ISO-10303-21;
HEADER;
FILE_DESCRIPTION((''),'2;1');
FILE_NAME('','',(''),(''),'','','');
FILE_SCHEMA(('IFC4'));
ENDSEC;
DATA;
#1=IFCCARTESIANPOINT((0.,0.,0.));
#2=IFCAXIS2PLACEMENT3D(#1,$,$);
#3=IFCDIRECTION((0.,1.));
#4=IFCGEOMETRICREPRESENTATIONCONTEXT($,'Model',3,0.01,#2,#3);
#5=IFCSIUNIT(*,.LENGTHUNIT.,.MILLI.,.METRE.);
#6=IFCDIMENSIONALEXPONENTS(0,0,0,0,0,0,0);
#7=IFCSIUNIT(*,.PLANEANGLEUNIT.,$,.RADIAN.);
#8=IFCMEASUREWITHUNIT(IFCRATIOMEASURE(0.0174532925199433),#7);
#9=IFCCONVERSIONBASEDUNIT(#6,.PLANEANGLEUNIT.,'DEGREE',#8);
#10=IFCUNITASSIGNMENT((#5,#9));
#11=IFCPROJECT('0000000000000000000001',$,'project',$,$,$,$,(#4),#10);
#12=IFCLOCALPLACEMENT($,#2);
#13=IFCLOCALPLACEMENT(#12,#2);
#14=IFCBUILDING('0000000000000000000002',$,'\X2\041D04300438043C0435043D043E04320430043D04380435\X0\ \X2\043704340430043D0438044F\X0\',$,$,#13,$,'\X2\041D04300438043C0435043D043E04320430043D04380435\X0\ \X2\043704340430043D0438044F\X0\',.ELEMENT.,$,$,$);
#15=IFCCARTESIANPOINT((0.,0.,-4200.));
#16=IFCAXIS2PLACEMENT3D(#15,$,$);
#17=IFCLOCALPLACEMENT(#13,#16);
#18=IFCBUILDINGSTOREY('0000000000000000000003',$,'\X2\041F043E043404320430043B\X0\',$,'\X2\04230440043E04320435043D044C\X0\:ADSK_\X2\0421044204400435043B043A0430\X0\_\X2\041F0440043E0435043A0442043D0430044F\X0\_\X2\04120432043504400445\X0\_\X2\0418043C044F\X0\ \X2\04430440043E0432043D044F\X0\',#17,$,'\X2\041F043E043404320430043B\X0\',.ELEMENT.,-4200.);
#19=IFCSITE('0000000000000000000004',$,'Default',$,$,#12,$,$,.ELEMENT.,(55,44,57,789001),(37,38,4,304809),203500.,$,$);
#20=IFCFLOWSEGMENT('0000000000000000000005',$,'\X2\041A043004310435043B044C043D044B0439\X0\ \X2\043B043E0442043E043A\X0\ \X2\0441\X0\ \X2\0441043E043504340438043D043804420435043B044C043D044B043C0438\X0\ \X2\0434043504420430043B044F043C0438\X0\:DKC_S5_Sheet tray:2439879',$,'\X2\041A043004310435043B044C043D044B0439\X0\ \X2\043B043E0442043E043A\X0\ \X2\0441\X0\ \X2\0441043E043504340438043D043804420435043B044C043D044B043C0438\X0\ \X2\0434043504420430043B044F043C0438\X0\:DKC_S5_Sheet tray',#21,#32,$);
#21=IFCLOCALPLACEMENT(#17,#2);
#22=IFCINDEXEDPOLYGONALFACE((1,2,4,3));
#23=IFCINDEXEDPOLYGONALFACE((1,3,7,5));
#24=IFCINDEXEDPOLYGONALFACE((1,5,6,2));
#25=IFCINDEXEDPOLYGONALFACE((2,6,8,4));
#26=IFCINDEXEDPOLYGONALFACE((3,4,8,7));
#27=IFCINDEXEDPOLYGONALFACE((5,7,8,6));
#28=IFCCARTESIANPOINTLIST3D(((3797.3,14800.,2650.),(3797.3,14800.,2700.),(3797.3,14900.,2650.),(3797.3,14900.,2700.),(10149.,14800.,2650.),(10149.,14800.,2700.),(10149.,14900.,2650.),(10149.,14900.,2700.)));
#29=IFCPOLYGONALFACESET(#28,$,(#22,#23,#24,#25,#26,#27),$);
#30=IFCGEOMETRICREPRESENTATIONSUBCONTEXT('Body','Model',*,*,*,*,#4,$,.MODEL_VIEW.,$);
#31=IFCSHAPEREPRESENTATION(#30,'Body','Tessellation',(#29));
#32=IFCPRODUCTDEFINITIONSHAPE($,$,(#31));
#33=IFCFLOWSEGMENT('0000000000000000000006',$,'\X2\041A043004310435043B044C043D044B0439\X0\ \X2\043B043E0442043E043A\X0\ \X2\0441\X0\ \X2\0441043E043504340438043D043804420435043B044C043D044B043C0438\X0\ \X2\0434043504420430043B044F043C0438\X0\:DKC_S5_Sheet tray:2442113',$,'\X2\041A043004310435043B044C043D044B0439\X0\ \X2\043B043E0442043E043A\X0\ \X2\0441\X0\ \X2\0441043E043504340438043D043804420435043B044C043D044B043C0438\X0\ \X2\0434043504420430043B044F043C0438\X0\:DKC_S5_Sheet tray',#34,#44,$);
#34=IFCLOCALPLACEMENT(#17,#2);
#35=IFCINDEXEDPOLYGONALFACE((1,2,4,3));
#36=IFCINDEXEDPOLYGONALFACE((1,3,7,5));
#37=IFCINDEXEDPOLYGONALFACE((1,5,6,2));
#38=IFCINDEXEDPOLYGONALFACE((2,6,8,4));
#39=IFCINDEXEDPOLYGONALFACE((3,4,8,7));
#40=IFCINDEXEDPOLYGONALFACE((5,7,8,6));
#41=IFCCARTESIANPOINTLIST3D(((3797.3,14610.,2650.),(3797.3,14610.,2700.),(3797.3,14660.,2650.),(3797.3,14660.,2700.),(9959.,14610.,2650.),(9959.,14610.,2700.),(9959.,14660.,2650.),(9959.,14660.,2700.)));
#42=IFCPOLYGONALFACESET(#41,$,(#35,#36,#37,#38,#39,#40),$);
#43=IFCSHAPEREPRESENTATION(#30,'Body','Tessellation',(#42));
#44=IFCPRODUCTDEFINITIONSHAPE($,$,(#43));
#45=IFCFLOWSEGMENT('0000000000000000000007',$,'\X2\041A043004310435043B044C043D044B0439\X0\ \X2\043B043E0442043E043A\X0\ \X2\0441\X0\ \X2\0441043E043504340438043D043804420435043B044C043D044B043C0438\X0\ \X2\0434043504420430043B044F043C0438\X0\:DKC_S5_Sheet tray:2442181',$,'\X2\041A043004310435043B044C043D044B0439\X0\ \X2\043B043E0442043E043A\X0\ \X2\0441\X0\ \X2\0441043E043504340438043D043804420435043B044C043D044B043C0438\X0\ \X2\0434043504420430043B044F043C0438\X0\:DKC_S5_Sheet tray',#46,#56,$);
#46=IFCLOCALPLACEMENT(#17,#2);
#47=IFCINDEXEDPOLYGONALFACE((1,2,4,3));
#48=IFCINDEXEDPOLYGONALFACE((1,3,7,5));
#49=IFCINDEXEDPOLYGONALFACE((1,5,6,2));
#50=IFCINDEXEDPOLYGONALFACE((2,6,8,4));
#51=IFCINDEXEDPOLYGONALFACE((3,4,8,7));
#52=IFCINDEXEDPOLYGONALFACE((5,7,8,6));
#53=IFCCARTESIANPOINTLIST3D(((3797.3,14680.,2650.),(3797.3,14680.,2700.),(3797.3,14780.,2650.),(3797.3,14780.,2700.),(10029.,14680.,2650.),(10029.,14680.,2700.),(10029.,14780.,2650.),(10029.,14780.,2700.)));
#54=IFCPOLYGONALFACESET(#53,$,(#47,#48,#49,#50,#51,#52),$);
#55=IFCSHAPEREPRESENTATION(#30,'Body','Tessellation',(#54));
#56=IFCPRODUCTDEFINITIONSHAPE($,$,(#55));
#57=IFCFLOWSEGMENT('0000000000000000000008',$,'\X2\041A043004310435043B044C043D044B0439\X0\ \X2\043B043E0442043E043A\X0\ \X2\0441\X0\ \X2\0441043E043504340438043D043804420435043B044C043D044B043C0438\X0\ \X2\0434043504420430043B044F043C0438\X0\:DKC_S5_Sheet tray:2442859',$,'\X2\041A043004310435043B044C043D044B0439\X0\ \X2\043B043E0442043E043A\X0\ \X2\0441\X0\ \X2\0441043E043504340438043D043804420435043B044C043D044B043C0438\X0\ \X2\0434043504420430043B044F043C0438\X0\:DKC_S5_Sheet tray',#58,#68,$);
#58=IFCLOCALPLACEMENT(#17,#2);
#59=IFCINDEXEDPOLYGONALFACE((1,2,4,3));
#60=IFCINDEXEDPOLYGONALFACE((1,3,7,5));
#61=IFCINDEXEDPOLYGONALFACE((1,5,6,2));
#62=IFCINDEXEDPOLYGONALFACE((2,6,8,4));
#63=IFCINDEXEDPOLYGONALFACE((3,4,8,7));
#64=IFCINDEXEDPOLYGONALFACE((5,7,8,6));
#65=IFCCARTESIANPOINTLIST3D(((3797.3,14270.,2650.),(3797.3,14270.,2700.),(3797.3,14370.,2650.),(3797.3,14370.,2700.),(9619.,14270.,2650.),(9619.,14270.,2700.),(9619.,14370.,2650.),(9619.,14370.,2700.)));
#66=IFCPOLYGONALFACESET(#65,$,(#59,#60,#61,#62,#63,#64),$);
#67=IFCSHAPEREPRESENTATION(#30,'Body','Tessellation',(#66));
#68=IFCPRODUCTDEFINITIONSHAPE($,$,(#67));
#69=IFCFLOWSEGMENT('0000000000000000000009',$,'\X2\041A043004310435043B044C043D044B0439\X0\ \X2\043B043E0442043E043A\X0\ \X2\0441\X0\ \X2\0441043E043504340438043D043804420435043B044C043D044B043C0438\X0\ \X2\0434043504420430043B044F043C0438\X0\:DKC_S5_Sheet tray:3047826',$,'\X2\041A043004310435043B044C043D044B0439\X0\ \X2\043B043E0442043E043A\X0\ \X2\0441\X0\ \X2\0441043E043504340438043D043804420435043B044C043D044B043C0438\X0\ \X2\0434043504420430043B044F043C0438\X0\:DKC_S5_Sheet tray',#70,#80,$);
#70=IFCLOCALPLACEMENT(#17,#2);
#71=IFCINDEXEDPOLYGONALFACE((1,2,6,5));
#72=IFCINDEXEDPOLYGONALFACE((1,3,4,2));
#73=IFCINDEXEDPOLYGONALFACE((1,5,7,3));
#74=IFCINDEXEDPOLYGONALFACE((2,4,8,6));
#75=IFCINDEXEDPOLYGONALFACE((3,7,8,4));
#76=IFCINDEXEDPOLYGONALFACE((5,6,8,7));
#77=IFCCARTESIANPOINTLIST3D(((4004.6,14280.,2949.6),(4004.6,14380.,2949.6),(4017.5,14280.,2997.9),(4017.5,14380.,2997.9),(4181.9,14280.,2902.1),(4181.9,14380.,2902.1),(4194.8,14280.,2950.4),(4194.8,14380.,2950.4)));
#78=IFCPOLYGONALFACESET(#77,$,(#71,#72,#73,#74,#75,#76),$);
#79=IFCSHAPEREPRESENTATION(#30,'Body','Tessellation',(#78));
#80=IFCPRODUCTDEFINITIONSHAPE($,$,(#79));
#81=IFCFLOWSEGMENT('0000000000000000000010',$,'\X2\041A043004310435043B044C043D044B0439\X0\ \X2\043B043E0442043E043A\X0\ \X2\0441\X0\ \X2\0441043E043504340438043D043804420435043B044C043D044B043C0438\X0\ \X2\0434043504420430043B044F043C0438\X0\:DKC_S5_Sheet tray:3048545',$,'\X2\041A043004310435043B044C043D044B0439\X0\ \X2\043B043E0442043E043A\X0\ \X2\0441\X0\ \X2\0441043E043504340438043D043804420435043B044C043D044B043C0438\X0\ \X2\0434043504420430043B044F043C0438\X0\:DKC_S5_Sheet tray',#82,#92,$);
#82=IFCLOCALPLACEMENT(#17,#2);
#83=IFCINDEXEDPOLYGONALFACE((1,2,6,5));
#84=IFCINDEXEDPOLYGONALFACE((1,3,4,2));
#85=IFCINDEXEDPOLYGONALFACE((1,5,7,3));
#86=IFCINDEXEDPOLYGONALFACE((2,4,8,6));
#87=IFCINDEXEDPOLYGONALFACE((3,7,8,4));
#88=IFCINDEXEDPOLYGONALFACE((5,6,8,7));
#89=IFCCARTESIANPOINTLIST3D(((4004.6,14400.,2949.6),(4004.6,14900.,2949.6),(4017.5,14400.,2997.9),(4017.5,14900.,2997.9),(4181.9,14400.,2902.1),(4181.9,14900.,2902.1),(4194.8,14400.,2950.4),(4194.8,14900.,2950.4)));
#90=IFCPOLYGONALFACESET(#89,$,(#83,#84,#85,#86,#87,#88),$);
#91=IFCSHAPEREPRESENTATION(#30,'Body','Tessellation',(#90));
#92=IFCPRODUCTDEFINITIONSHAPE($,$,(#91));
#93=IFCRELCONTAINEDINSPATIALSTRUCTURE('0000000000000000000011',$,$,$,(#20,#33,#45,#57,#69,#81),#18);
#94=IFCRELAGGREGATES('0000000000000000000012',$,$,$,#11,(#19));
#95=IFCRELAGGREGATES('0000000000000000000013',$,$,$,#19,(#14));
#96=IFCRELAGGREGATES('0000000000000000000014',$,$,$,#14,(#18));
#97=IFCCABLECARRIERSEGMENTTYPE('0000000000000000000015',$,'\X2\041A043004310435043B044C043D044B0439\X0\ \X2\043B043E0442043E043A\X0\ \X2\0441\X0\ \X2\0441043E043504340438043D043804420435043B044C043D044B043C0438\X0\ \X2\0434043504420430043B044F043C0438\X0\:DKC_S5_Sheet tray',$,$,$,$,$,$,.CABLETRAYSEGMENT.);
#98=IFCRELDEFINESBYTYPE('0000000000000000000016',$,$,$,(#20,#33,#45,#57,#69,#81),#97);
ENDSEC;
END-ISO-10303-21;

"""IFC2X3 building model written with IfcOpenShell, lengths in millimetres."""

from ifc_helpers import new_model, entity, si_unit, converted_unit, direction, frame, frame_2d, origin, origin_2d_with_axis, place, context, subcontext, project, spatial, rectangle, extrude, type_object, element, save


model = new_model("IFC2X3")

# Units and contexts
model_context = context("Model", 3, precision=0.01, world=origin(), true_north=direction((0.0, 1.0)))
body_context = subcontext(model_context, "Body", "Model", "MODEL_VIEW")
ifc_project = project(units=[si_unit("LENGTHUNIT", "METRE", prefix="MILLI"), converted_unit("PLANEANGLEUNIT", "DEGREE", entity("IfcRatioMeasure", 0.0174532925199433), si_unit("PLANEANGLEUNIT", "RADIAN"), dimensions=[0, 0, 0, 0, 0, 0, 0])], contexts=[model_context])

# Site, building, storey
site_placement = place(None, origin())
site = spatial("IfcSite", under=ifc_project, at=site_placement, Name="Default", CompositionType="ELEMENT", RefLatitude=(55, 44, 57, 789001), RefLongitude=(37, 38, 4, 304809), RefElevation=203500.0)
building_placement = place(site_placement, origin())
building = spatial("IfcBuilding", under=site, at=building_placement, Name="Наименование здания", LongName="Наименование здания", CompositionType="ELEMENT")
storey_placement = place(building_placement, frame((0.0, 0.0, -4200.0)))
storey = spatial("IfcBuildingStorey", under=building, at=storey_placement, Name="Подвал", ObjectType="Уровень:ADSK_Стрелка_Проектная_Вверх_Имя уровня", LongName="Подвал", CompositionType="ELEMENT", Elevation=-4200.0)

# Flow segments
cable_carrier_segment_type = type_object("IfcCableCarrierSegmentType", Name="Кабельный лоток с соединительными деталями:DKC_S5_Sheet tray", PredefinedType="CABLETRAYSEGMENT")
flow_segment_1_placement = place(storey_placement, frame((3797.2, 14800.0, 2650.0)))
element("IfcFlowSegment", 1, at=flow_segment_1_placement, inside=storey, type_object=cable_carrier_segment_type, Name="Кабельный лоток с соединительными деталями:DKC_S5_Sheet tray:2439879", ObjectType="Кабельный лоток с соединительными деталями:DKC_S5_Sheet tray", context=body_context, shape_type="SweptSolid", body=[
    extrude(rectangle(XDim=6351.8, YDim=100.0, at=origin_2d_with_axis()), frame((3175.9, 50.0, 0.0), z_axis=(0.0, 0.0, 1.0), x_axis=(-1.0, 0.0, 0.0)), (0.0, 0.0, 1.0), 50.0),
])
flow_segment_2_placement = place(storey_placement, frame((3797.2, 14610.0, 2650.0)))
element("IfcFlowSegment", 2, at=flow_segment_2_placement, inside=storey, type_object=cable_carrier_segment_type, Name="Кабельный лоток с соединительными деталями:DKC_S5_Sheet tray:2442113", ObjectType="Кабельный лоток с соединительными деталями:DKC_S5_Sheet tray", context=body_context, shape_type="SweptSolid", body=[
    extrude(rectangle(XDim=6161.8, YDim=50.0, at=origin_2d_with_axis()), frame((3080.9, 25.0, 0.0), z_axis=(0.0, 0.0, 1.0), x_axis=(-1.0, 0.0, 0.0)), (0.0, 0.0, 1.0), 50.0),
])
flow_segment_3_placement = place(storey_placement, frame((3797.2, 14680.0, 2650.0)))
element("IfcFlowSegment", 3, at=flow_segment_3_placement, inside=storey, type_object=cable_carrier_segment_type, Name="Кабельный лоток с соединительными деталями:DKC_S5_Sheet tray:2442181", ObjectType="Кабельный лоток с соединительными деталями:DKC_S5_Sheet tray", context=body_context, shape_type="SweptSolid", body=[
    extrude(rectangle(XDim=6231.8, YDim=100.0, at=origin_2d_with_axis()), frame((3115.9, 50.0, 0.0), z_axis=(0.0, 0.0, 1.0), x_axis=(-1.0, 0.0, 0.0)), (0.0, 0.0, 1.0), 50.0),
])
flow_segment_4_placement = place(storey_placement, frame((3797.2, 14270.0, 2650.0)))
element("IfcFlowSegment", 4, at=flow_segment_4_placement, inside=storey, type_object=cable_carrier_segment_type, Name="Кабельный лоток с соединительными деталями:DKC_S5_Sheet tray:2442859", ObjectType="Кабельный лоток с соединительными деталями:DKC_S5_Sheet tray", context=body_context, shape_type="SweptSolid", body=[
    extrude(rectangle(XDim=5821.8, YDim=100.0, at=origin_2d_with_axis()), frame((2910.9, 50.0, 0.0), z_axis=(0.0, 0.0, 1.0), x_axis=(-1.0, 0.0, 0.0)), (0.0, 0.0, 1.0), 50.0),
])
flow_segment_5_placement = place(storey_placement, frame((4004.6, 14280.0, 2902.1)))
element("IfcFlowSegment", 5, at=flow_segment_5_placement, inside=storey, type_object=cable_carrier_segment_type, Name="Кабельный лоток с соединительными деталями:DKC_S5_Sheet tray:3047826", ObjectType="Кабельный лоток с соединительными деталями:DKC_S5_Sheet tray", context=body_context, shape_type="SweptSolid", body=[
    extrude(rectangle(XDim=50.0, YDim=100.0, at=origin_2d_with_axis()), frame((6.5, 50.0, 71.7), z_axis=(0.965926, 0.0, -0.258819), x_axis=(0.258819, 0.0, 0.965926)), (0.0, 0.0, 1.0), 183.5),
])
flow_segment_6_placement = place(storey_placement, frame((4004.6, 14400.0, 2902.1)))
element("IfcFlowSegment", 6, at=flow_segment_6_placement, inside=storey, type_object=cable_carrier_segment_type, Name="Кабельный лоток с соединительными деталями:DKC_S5_Sheet tray:3048545", ObjectType="Кабельный лоток с соединительными деталями:DKC_S5_Sheet tray", context=body_context, shape_type="SweptSolid", body=[
    extrude(rectangle(XDim=50.0, YDim=183.5, at=frame_2d((0.0, 0.0), x_axis=(0.0, 1.0))), frame((95.1, 0.0, 47.9), z_axis=(0.0, 1.0, 0.0), x_axis=(-0.965926, 0.0, 0.258819)), (0.0, 0.0, 1.0), 500.0),
])

save(model, "model.ifc")
